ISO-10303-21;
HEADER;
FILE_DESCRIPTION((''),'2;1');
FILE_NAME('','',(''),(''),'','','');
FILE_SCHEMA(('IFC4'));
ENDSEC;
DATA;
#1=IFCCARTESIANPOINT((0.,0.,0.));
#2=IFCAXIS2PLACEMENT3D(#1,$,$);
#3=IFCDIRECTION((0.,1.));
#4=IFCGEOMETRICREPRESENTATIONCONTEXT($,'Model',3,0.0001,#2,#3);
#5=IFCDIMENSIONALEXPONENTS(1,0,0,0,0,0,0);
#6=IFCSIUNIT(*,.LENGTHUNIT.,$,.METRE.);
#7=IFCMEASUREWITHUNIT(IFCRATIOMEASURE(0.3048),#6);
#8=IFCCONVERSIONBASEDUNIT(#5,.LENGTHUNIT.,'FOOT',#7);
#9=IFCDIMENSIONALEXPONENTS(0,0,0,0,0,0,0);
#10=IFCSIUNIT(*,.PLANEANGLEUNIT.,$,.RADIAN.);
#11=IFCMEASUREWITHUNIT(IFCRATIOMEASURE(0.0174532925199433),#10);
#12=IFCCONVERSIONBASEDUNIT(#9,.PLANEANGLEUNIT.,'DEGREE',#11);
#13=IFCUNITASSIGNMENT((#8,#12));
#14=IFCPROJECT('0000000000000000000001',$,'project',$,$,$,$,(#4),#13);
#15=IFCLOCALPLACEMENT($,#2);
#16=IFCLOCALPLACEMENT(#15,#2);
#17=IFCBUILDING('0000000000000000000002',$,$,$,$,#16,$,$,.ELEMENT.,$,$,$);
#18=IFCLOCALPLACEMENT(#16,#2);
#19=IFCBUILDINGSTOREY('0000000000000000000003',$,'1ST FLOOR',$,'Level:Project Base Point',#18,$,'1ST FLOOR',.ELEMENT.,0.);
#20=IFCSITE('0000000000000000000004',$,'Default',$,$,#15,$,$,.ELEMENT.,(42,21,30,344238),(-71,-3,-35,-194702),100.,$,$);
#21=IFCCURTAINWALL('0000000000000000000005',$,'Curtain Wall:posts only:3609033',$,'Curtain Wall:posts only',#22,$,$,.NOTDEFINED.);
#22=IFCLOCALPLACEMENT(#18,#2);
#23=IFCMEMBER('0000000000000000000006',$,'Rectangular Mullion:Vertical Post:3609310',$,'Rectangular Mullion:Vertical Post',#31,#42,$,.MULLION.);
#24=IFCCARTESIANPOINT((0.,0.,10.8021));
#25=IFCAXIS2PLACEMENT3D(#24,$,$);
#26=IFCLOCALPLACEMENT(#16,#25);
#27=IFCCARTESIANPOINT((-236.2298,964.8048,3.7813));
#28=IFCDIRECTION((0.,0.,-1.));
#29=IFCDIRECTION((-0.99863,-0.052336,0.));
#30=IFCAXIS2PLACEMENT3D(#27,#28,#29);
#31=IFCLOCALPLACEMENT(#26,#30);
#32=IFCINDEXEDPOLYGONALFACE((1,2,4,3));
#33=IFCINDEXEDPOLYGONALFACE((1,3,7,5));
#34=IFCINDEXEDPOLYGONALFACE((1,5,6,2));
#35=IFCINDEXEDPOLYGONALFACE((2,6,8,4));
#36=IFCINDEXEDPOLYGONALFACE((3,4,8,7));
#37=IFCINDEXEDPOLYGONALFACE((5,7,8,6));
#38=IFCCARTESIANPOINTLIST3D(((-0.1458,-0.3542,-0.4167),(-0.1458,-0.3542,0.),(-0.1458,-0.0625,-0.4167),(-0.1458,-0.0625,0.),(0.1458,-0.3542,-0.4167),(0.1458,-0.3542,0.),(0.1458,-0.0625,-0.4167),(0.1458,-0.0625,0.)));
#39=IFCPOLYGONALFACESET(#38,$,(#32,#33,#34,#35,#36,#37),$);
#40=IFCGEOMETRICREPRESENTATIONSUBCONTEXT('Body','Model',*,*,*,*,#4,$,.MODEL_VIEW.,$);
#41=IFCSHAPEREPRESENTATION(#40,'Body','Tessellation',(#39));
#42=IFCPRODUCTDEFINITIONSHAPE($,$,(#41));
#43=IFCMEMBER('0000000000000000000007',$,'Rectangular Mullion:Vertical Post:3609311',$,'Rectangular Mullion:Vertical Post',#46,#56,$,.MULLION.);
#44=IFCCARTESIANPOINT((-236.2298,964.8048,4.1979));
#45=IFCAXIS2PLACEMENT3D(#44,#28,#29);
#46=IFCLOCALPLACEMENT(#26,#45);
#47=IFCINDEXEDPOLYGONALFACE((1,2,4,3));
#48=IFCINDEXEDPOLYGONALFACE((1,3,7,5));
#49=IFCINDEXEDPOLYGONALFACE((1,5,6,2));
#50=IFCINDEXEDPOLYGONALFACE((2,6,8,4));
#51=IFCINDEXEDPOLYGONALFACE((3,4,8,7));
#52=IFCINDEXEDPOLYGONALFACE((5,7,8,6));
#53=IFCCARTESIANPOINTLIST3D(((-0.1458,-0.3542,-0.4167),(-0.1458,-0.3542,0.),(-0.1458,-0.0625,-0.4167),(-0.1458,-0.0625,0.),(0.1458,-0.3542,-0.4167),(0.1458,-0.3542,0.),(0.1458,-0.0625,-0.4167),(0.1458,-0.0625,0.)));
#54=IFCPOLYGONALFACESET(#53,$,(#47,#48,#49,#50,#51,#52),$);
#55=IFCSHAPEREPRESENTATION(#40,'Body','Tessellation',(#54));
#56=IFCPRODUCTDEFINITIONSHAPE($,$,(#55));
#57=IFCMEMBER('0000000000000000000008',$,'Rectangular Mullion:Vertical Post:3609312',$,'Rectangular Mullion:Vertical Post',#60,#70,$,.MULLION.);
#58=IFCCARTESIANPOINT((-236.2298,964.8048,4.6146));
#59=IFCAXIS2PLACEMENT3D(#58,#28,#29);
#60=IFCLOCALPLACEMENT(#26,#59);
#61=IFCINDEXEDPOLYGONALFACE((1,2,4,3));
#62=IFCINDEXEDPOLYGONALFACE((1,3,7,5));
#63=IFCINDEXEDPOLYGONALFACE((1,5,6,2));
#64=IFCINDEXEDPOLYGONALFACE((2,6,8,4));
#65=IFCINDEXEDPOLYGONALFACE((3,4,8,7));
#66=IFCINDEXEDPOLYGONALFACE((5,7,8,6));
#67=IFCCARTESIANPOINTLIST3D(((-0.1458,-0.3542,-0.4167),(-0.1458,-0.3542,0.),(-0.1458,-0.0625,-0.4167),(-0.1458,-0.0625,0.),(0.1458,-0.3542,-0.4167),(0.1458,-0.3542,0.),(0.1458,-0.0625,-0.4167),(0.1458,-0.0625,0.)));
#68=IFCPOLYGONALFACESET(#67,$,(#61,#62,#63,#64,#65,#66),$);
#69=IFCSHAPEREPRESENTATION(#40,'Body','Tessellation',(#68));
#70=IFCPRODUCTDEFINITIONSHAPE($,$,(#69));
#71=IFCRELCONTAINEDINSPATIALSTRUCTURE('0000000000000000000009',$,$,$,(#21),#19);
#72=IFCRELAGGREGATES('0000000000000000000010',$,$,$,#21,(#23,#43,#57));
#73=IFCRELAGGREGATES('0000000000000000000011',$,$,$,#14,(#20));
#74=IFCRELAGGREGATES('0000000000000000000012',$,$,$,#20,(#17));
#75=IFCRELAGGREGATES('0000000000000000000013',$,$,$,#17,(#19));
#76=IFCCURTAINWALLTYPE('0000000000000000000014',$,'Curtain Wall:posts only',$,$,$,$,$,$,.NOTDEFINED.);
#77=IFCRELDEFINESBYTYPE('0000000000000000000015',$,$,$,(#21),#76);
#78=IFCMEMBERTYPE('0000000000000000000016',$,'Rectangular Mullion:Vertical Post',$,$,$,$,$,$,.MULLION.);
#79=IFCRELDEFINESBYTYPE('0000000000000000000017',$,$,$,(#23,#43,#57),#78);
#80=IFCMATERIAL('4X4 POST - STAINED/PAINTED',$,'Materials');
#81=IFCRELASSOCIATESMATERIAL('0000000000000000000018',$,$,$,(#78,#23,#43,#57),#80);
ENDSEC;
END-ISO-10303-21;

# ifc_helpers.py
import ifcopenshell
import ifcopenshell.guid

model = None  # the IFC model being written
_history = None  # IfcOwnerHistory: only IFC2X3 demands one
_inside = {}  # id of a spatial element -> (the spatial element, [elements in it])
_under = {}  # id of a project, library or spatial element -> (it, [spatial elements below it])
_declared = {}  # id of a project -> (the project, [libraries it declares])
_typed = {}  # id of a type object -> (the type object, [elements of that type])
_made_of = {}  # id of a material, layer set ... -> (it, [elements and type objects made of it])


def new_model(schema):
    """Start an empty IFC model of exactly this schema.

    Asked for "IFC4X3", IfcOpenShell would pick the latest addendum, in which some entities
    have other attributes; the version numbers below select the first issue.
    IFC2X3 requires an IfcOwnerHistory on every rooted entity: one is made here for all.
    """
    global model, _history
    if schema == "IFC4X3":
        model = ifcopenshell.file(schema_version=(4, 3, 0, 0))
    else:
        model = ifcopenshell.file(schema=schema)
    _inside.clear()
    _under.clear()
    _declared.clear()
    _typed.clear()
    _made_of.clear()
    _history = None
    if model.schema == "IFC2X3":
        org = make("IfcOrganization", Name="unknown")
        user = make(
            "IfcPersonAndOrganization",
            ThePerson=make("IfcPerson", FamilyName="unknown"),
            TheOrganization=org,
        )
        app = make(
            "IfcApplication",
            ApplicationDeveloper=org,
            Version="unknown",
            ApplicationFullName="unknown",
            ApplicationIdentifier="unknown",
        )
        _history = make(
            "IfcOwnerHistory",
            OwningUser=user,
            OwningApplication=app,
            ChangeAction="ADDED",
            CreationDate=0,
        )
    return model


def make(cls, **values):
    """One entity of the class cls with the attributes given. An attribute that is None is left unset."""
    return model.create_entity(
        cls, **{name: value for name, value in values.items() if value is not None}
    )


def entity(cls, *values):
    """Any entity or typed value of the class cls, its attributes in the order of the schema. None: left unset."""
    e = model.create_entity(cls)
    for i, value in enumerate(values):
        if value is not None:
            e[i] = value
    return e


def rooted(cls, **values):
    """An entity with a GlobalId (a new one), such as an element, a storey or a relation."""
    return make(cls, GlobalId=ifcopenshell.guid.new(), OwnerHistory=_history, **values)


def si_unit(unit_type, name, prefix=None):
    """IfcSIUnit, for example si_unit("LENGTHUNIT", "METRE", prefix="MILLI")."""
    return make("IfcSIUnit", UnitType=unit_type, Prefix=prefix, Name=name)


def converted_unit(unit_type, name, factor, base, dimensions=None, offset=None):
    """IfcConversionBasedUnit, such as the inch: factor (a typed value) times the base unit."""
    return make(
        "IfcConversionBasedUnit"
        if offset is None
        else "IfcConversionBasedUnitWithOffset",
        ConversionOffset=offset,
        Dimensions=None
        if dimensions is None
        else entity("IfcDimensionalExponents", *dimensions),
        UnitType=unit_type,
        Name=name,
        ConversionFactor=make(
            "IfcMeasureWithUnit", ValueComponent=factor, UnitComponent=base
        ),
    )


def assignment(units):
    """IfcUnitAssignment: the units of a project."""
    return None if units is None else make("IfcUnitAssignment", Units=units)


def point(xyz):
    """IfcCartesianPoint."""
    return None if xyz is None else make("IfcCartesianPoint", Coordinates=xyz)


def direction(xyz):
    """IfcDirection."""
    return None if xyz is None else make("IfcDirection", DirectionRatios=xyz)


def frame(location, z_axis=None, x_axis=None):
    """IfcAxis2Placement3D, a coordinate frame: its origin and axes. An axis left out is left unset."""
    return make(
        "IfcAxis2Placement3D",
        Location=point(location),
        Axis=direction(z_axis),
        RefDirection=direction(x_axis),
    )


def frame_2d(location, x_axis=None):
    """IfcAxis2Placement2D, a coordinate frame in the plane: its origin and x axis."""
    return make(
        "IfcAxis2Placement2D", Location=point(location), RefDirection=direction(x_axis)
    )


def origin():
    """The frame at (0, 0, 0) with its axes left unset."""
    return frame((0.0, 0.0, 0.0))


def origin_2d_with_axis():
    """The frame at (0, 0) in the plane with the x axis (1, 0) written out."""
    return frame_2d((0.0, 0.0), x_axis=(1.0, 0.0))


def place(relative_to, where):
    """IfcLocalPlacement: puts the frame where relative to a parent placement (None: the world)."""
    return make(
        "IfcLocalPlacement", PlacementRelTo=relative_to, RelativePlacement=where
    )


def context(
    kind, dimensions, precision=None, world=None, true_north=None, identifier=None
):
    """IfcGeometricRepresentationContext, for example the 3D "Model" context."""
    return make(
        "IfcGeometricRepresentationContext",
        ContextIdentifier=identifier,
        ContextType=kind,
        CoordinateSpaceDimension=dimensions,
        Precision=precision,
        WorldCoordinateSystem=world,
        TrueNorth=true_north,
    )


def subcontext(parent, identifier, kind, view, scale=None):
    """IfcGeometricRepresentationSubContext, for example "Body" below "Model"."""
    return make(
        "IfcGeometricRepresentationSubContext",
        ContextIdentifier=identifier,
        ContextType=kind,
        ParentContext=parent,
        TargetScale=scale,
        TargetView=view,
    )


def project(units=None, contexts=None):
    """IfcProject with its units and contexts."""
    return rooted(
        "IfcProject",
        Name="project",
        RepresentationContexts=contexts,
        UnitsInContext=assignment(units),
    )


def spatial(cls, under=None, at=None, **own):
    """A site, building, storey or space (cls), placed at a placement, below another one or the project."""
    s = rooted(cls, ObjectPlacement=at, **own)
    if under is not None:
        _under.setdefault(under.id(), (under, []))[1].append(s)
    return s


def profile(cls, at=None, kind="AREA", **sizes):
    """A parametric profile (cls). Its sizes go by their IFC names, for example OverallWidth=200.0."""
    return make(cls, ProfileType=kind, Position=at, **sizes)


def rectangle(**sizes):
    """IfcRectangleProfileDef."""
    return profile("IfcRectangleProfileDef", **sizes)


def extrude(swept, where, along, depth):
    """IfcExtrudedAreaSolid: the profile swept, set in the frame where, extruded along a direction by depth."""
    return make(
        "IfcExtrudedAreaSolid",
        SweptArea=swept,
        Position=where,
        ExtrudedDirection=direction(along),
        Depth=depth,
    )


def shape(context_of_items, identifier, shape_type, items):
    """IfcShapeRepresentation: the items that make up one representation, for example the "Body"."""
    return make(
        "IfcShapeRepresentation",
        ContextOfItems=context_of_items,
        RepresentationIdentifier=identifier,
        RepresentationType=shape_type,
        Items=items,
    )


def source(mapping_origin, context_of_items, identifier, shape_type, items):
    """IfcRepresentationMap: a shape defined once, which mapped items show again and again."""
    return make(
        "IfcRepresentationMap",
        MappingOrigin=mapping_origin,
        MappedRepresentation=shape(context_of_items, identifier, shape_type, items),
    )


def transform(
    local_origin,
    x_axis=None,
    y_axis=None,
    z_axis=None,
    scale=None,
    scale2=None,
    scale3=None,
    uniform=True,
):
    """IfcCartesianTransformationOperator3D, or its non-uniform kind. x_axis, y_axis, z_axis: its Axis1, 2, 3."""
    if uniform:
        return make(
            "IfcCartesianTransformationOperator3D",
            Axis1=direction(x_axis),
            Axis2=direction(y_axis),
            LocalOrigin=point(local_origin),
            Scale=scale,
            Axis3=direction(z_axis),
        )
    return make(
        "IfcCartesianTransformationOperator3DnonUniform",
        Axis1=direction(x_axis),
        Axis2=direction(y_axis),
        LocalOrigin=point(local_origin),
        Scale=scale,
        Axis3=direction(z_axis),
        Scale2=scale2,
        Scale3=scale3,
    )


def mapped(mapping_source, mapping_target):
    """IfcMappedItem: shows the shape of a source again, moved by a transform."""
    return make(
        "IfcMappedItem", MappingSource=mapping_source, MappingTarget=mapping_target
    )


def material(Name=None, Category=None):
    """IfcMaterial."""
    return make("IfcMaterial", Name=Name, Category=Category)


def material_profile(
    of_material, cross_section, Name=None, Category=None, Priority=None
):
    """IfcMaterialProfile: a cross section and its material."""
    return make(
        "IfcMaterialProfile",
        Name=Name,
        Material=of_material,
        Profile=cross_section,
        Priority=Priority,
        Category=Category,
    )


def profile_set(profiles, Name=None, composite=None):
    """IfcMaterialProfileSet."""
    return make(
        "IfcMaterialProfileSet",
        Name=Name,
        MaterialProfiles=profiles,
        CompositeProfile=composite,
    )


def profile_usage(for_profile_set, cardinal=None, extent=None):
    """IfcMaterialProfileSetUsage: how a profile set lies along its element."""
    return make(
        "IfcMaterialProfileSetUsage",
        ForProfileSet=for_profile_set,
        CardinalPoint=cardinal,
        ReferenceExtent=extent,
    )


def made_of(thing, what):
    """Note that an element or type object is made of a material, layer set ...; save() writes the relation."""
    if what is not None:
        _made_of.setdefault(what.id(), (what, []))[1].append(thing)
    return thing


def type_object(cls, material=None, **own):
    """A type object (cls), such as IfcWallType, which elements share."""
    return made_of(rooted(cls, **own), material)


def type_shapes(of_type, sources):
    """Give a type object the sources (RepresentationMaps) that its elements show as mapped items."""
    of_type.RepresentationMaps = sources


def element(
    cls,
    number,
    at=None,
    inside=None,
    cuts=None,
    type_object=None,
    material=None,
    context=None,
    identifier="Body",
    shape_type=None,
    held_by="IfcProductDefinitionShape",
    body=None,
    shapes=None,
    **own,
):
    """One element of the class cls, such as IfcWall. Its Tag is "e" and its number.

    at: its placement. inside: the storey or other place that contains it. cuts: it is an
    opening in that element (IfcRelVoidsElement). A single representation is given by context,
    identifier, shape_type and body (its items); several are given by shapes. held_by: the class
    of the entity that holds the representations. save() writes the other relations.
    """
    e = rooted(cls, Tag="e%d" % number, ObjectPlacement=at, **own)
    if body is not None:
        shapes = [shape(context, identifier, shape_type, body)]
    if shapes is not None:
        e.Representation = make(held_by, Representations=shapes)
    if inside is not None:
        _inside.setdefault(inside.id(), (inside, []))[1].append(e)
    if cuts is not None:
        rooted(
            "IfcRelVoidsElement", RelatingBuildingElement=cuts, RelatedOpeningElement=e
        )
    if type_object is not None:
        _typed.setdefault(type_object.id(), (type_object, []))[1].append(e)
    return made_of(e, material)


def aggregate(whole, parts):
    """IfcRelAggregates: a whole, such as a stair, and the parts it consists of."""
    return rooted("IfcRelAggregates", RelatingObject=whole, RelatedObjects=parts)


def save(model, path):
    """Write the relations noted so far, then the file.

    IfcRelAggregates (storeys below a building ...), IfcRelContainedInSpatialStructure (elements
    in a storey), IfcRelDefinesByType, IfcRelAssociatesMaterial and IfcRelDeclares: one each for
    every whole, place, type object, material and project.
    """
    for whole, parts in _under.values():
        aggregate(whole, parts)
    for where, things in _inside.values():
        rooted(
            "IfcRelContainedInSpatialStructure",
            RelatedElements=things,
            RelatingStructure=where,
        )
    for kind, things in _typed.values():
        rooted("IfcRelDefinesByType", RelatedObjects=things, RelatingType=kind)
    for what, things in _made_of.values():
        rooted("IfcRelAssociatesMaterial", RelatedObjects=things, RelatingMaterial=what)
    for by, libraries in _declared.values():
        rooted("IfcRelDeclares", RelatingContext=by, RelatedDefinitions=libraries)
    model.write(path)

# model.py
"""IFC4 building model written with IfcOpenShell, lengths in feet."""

from ifc_helpers import new_model, entity, si_unit, converted_unit, direction, frame, origin, origin_2d_with_axis, place, context, subcontext, project, spatial, rectangle, extrude, source, transform, mapped, material, material_profile, profile_set, profile_usage, type_object, type_shapes, element, aggregate, save


model = new_model("IFC4")

# Units and contexts
model_context = context("Model", 3, precision=0.0001, world=origin(), true_north=direction((0.0, 1.0)))
body_context = subcontext(model_context, "Body", "Model", "MODEL_VIEW")
ifc_project = project(units=[converted_unit("LENGTHUNIT", "FOOT", entity("IfcRatioMeasure", 0.3048), si_unit("LENGTHUNIT", "METRE"), dimensions=[1, 0, 0, 0, 0, 0, 0]), converted_unit("PLANEANGLEUNIT", "DEGREE", entity("IfcRatioMeasure", 0.0174532925199433), si_unit("PLANEANGLEUNIT", "RADIAN"), dimensions=[0, 0, 0, 0, 0, 0, 0])], contexts=[model_context])

# Site, building, storey
site_placement = place(None, origin())
site = spatial("IfcSite", under=ifc_project, at=site_placement, Name="Default", CompositionType="ELEMENT", RefLatitude=(42, 21, 30, 344238), RefLongitude=(-71, -3, -35, -194702), RefElevation=100.0)
building_placement = place(site_placement, origin())
building = spatial("IfcBuilding", under=site, at=building_placement, CompositionType="ELEMENT")
storey_placement = place(building_placement, origin())
storey = spatial("IfcBuildingStorey", under=building, at=storey_placement, Name="1ST FLOOR", ObjectType="Level:Project Base Point", LongName="1ST FLOOR", CompositionType="ELEMENT", Elevation=0.0)

# Curtain wall, members
curtain_wall_type_1 = type_object("IfcCurtainWallType", Name="Curtain Wall:posts only", PredefinedType="NOTDEFINED")
curtain_wall_1_placement = place(storey_placement, origin())
curtain_wall_1 = element("IfcCurtainWall", 1, at=curtain_wall_1_placement, inside=storey, type_object=curtain_wall_type_1, Name="Curtain Wall:posts only:3609033", ObjectType="Curtain Wall:posts only", PredefinedType="NOTDEFINED")
ifc_material_1 = material(Name="4X4 POST - STAINED/PAINTED", Category="Materials")
ifc_material_profile_1 = material_profile(ifc_material_1, rectangle(XDim=0.2917, YDim=0.2917, at=origin_2d_with_axis()), Name="Vertical Post")
ifc_profile_set_1 = profile_set([ifc_material_profile_1], Name="Vertical Post")
ifc_profile_usage_1 = profile_usage(ifc_profile_set_1)
member_type_1 = type_object("IfcMemberType", Name="Rectangular Mullion:Vertical Post", PredefinedType="MULLION", material=ifc_profile_set_1)
shared_shape_1 = source(origin(), body_context, "Body", "SweptSolid", [
    extrude(rectangle(XDim=0.2917, YDim=0.2917, at=origin_2d_with_axis()), frame((0.0, -0.2083, -0.4167), z_axis=(0.0, 0.0, 1.0), x_axis=(0.0, -1.0, 0.0)), (0.0, 0.0, 1.0), 0.4167),
])
type_shapes(member_type_1, [shared_shape_1])
placement = place(building_placement, frame((0.0, 0.0, 10.8021)))
member_1_placement = place(placement, frame((-236.2298, 964.8048, 3.7813), z_axis=(0.0, 0.0, -1.0), x_axis=(-0.99863, -0.052336, 0.0)))
member_1 = element("IfcMember", 2, at=member_1_placement, type_object=member_type_1, material=ifc_profile_usage_1, Name="Rectangular Mullion:Vertical Post:3609310", ObjectType="Rectangular Mullion:Vertical Post", PredefinedType="MULLION", context=body_context, shape_type="MappedRepresentation", body=[
    mapped(shared_shape_1, transform((0.0, 0.0, 0.0), scale=1.0)),
])
ifc_profile_usage_2 = profile_usage(ifc_profile_set_1)
member_2_placement = place(placement, frame((-236.2298, 964.8048, 4.1979), z_axis=(0.0, 0.0, -1.0), x_axis=(-0.99863, -0.052336, 0.0)))
member_2 = element("IfcMember", 3, at=member_2_placement, type_object=member_type_1, material=ifc_profile_usage_2, Name="Rectangular Mullion:Vertical Post:3609311", ObjectType="Rectangular Mullion:Vertical Post", PredefinedType="MULLION", context=body_context, shape_type="MappedRepresentation", body=[
    mapped(shared_shape_1, transform((0.0, 0.0, 0.0), scale=1.0)),
])
ifc_profile_usage_3 = profile_usage(ifc_profile_set_1)
member_3_placement = place(placement, frame((-236.2298, 964.8048, 4.6146), z_axis=(0.0, 0.0, -1.0), x_axis=(-0.99863, -0.052336, 0.0)))
member_3 = element("IfcMember", 4, at=member_3_placement, type_object=member_type_1, material=ifc_profile_usage_3, Name="Rectangular Mullion:Vertical Post:3609312", ObjectType="Rectangular Mullion:Vertical Post", PredefinedType="MULLION", context=body_context, shape_type="MappedRepresentation", body=[
    mapped(shared_shape_1, transform((0.0, 0.0, 0.0), scale=1.0)),
])
aggregate(curtain_wall_1, [member_1, member_2, member_3])

save(model, "model.ifc")
